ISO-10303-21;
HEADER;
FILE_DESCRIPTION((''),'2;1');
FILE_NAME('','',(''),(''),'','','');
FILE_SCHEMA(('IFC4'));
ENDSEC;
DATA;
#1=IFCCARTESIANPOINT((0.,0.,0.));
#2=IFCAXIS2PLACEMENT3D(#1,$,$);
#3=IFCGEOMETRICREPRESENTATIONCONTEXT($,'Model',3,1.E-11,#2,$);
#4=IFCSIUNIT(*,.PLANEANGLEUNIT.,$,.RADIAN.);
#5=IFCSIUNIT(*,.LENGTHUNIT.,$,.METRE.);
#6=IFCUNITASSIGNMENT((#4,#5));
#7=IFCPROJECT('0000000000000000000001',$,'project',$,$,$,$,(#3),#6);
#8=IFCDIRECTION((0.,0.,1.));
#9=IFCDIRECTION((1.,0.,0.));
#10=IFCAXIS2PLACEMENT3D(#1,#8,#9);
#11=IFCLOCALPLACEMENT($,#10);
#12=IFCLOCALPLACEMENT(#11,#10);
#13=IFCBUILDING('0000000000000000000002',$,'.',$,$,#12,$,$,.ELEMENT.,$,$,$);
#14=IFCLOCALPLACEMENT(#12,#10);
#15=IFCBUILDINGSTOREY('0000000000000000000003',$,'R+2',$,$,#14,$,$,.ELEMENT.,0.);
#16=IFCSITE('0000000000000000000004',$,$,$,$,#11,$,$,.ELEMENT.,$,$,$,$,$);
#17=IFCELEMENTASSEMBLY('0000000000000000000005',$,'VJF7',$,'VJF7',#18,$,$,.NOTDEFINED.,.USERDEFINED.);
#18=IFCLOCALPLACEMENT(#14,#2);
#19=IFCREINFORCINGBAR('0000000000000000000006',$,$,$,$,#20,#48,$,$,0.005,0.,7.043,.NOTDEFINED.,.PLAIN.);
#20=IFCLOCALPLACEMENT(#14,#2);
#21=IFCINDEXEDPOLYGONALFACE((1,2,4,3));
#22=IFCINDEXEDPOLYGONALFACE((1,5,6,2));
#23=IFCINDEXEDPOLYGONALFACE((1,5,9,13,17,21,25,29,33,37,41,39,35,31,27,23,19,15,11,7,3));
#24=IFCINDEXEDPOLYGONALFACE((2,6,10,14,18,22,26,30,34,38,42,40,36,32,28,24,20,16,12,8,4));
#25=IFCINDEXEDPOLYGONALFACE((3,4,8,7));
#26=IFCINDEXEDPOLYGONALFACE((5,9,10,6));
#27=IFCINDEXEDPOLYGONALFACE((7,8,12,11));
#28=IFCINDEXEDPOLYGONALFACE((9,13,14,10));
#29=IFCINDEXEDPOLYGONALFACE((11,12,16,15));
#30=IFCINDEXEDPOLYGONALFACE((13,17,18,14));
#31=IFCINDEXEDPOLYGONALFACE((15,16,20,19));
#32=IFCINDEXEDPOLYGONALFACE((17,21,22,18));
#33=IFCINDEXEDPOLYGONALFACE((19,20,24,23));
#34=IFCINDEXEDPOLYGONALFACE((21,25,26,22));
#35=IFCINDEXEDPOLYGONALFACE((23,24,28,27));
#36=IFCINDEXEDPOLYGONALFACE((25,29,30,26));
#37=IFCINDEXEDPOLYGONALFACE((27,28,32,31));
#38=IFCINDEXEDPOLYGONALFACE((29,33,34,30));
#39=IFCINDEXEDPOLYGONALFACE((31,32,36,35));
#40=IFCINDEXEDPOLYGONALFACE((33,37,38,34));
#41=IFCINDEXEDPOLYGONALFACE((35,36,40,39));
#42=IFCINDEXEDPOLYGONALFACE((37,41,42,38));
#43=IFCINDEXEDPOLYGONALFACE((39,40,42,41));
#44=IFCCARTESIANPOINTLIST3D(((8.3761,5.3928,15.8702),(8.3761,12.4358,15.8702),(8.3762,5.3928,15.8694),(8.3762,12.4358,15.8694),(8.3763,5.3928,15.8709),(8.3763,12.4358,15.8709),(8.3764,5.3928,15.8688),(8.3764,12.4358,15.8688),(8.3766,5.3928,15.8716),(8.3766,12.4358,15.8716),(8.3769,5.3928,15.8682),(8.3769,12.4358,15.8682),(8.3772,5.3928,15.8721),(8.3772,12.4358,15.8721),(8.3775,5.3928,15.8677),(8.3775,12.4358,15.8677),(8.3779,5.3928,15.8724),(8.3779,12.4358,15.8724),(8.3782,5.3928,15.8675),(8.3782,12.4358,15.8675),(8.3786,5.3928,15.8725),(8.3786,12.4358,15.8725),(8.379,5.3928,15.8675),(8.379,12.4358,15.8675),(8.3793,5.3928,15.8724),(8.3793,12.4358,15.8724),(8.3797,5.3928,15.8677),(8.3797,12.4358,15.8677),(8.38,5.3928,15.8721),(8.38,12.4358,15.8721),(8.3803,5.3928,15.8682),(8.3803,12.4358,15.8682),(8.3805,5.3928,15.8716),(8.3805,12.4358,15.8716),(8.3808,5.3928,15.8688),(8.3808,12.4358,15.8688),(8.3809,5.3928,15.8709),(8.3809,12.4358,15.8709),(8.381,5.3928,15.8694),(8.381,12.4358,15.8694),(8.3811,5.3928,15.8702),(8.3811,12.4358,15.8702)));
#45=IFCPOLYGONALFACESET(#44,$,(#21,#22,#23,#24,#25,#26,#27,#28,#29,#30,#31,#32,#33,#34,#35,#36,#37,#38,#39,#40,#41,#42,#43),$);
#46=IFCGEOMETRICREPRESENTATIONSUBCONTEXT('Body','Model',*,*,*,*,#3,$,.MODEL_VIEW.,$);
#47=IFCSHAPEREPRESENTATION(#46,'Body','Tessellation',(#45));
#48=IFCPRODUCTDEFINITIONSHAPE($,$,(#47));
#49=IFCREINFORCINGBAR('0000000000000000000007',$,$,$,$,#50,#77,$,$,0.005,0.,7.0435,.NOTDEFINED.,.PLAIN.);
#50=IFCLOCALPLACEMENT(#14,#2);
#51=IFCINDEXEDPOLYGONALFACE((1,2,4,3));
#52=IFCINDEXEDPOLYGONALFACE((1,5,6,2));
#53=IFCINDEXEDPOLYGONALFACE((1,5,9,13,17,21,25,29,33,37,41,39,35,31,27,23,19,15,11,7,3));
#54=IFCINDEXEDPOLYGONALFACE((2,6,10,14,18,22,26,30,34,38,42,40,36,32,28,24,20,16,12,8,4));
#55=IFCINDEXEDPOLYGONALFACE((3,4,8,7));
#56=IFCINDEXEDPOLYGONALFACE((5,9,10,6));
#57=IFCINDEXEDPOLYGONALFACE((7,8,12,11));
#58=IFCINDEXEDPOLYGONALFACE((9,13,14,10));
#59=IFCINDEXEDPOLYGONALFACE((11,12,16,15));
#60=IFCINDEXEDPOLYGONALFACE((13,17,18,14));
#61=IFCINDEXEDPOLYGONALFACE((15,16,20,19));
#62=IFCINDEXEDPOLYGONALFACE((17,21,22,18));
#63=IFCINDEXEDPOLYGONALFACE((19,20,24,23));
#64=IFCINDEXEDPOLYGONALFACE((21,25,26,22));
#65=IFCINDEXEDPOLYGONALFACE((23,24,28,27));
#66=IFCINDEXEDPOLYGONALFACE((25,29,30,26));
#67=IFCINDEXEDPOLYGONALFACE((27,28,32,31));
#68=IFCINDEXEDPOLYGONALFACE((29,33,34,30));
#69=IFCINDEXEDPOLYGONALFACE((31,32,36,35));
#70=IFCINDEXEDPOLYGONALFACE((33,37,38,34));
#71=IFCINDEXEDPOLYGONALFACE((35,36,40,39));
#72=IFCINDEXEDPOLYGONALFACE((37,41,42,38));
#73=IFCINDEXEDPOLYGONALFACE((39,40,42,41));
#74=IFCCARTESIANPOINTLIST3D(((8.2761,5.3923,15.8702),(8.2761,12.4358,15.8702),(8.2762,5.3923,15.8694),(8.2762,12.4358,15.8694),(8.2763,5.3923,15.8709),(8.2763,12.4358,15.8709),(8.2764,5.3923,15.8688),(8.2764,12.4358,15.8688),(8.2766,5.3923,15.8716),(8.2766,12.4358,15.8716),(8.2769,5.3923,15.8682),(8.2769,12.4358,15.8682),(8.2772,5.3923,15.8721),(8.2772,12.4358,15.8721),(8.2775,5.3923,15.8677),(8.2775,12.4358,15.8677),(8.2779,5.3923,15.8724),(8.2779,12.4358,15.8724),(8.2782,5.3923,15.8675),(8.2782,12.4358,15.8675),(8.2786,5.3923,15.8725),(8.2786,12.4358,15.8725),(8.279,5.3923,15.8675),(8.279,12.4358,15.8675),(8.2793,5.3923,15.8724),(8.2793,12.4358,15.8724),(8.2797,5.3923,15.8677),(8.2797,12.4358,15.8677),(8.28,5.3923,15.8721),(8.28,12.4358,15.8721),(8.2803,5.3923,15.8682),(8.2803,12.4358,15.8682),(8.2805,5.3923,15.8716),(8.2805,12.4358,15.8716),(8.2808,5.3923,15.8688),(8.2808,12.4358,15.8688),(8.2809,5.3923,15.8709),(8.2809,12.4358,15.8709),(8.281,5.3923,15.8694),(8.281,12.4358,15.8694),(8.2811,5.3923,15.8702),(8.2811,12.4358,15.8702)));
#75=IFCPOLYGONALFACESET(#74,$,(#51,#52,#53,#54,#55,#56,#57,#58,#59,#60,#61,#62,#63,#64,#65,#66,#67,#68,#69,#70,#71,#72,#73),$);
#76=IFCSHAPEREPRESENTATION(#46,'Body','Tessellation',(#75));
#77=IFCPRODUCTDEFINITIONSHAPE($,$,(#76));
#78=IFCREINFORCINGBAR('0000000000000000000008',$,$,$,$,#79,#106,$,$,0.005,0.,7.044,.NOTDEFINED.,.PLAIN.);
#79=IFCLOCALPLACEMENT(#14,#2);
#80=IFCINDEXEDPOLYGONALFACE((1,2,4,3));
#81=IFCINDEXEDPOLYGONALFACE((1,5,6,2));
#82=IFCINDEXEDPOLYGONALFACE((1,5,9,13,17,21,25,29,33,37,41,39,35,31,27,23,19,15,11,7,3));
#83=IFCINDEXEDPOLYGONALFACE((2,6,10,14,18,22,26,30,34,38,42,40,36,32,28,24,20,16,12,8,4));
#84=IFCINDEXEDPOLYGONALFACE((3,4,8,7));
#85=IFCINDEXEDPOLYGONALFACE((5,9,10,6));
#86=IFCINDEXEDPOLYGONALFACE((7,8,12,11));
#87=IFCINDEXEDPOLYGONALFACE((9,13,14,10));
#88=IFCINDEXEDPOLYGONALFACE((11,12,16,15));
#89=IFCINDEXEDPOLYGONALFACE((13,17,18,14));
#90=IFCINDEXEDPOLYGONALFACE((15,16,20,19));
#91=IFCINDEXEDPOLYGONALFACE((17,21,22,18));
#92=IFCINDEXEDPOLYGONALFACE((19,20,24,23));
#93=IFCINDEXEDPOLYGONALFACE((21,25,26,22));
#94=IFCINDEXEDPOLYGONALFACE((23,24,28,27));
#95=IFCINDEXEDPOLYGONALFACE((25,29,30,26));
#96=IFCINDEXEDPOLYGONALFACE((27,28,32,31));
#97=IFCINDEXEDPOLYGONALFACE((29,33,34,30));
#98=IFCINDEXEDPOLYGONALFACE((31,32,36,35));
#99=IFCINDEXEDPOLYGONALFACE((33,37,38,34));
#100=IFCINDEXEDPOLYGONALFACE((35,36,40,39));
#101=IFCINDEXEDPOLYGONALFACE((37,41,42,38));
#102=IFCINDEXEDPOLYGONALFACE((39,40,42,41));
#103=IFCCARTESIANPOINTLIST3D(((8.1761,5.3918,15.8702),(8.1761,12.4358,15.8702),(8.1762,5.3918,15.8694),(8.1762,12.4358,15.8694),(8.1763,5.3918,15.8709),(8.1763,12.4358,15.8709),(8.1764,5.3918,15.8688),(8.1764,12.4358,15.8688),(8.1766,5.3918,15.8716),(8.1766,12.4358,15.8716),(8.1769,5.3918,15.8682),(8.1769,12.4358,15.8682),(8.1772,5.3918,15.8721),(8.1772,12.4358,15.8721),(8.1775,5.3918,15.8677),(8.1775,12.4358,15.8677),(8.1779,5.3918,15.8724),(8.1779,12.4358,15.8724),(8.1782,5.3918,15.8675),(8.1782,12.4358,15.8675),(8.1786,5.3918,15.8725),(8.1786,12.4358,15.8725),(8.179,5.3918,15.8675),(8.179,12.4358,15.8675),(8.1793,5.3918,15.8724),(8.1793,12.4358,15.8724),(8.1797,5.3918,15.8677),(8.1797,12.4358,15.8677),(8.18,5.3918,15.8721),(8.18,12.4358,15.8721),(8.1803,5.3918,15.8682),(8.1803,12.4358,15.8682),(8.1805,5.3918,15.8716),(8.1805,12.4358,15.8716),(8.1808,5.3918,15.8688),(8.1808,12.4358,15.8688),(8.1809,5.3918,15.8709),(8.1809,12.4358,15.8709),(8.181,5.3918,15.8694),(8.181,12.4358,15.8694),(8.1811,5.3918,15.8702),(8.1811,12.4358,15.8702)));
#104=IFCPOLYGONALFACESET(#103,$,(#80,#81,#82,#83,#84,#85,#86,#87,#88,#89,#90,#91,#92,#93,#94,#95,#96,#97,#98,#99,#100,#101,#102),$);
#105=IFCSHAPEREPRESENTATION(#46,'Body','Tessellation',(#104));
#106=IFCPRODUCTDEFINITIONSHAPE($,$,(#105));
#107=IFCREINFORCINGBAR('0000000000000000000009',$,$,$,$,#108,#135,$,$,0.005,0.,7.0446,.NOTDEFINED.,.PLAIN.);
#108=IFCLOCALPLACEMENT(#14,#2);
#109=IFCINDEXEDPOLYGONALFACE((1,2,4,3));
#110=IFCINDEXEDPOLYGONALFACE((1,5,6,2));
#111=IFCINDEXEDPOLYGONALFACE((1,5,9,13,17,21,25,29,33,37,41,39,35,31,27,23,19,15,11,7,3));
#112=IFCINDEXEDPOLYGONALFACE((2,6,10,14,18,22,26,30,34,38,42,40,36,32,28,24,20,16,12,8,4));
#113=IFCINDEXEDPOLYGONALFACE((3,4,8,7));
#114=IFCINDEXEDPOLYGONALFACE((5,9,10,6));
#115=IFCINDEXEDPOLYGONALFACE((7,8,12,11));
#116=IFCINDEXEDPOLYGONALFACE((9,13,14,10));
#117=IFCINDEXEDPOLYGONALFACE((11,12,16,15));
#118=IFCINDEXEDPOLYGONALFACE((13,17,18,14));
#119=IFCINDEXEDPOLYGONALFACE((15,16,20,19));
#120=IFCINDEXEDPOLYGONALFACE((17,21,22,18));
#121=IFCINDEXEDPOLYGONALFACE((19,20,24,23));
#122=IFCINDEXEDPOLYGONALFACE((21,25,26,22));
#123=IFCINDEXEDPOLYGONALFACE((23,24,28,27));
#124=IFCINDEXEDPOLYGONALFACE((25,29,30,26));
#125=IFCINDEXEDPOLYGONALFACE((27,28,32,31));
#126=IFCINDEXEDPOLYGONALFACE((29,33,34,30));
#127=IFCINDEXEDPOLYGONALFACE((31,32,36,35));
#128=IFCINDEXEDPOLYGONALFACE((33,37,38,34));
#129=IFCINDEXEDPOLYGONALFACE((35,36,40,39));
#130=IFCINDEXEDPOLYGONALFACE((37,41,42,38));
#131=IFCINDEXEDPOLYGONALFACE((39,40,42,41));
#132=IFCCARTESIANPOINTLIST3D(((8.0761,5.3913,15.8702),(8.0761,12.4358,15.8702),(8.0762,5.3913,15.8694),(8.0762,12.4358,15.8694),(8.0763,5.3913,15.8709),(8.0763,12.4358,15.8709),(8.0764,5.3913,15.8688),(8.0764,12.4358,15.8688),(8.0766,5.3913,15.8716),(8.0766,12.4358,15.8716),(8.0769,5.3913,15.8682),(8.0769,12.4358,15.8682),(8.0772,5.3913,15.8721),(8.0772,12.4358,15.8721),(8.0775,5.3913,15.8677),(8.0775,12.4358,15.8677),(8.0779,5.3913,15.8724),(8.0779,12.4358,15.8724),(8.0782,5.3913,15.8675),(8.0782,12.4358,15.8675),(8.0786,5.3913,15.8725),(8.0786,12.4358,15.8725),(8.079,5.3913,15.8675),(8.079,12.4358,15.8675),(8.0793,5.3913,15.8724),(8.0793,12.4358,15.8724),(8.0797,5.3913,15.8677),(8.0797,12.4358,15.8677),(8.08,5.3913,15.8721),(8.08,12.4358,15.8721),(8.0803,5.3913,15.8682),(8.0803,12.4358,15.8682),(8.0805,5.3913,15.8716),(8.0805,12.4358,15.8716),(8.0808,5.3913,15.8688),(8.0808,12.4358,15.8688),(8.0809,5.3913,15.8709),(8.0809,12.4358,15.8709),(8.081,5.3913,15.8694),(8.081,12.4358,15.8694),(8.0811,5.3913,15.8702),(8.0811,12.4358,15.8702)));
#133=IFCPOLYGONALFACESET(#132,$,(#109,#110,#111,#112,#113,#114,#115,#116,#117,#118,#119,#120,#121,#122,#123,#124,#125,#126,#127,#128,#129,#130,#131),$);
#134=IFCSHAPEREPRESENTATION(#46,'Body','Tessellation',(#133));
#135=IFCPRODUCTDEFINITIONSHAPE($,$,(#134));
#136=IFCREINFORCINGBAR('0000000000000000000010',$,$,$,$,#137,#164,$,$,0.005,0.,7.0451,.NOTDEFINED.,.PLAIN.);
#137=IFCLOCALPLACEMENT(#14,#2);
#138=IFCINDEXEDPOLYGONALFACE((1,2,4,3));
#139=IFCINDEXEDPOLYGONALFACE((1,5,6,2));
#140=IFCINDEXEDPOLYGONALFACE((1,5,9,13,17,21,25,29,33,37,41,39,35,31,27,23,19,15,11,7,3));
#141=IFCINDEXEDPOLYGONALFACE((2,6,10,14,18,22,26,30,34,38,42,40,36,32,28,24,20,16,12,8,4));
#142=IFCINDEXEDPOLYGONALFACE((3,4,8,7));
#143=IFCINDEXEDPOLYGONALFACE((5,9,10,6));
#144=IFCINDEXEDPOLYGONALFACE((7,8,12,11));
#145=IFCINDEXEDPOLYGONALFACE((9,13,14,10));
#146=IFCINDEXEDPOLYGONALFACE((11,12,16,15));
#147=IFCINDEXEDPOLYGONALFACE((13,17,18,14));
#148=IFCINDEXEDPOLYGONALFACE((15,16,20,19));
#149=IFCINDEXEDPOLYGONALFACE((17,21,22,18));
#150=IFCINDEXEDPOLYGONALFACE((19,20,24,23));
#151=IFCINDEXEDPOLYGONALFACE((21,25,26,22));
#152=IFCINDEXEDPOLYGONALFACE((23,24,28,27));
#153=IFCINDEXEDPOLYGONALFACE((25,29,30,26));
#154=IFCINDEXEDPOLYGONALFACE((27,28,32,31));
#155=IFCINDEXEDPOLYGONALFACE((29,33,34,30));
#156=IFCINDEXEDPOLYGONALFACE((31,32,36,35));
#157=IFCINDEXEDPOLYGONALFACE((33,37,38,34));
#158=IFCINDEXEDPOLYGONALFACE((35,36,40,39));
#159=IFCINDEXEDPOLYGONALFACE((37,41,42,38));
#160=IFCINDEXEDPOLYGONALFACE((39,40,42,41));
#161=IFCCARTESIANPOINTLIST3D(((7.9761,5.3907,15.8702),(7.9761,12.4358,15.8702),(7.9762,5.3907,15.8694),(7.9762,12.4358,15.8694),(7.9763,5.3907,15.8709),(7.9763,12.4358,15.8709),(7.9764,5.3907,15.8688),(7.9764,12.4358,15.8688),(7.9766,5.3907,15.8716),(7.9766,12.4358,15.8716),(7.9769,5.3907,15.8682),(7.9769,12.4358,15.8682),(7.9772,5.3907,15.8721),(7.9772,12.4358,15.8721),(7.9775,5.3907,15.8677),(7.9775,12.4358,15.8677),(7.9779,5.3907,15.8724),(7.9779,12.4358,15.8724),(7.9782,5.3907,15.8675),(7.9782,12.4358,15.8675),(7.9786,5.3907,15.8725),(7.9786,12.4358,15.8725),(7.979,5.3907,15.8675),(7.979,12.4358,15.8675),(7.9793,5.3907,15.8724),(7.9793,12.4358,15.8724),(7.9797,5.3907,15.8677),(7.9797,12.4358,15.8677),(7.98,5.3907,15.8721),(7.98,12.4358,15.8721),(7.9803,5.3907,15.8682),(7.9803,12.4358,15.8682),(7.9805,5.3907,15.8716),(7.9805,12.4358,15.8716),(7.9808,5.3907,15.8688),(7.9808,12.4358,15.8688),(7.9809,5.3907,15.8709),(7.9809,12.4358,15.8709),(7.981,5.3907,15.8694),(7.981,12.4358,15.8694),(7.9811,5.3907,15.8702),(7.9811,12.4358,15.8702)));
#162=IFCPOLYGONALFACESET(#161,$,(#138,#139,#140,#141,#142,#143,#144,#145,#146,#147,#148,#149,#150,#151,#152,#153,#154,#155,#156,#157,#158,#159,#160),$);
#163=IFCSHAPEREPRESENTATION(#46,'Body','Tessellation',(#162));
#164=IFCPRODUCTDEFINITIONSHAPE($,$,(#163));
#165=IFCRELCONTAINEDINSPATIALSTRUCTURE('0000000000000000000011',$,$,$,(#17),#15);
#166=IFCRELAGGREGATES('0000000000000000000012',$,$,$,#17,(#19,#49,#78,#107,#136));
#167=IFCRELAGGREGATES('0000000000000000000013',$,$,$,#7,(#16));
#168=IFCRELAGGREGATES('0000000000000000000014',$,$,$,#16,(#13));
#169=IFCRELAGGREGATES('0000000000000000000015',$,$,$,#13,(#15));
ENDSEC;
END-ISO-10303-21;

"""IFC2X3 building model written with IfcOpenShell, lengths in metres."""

from ifc_helpers import new_model, entity, si_unit, origin, origin_with_axes, place, context, subcontext, project, spatial, shape, element, aggregate, save


model = new_model("IFC2X3")

# Units and contexts
model_context = context("Model", 3, precision=1e-11, world=origin())
body_context = subcontext(model_context, "Body", "Model", "MODEL_VIEW")
ifc_project = project(units=[si_unit("PLANEANGLEUNIT", "RADIAN"), si_unit("LENGTHUNIT", "METRE")], contexts=[model_context])

# Site, building, storey
site_placement = place(None, origin_with_axes())
site = spatial("IfcSite", under=ifc_project, at=site_placement, CompositionType="ELEMENT")
building_placement = place(site_placement, origin_with_axes())
building = spatial("IfcBuilding", under=site, at=building_placement, Name=".", CompositionType="ELEMENT")
storey_placement = place(building_placement, origin_with_axes())
storey = spatial("IfcBuildingStorey", under=building, at=storey_placement, Name="R+2", CompositionType="ELEMENT", Elevation=0.0)

# Element assembly, reinforcing bars
assembly_1_placement = place(storey_placement, origin_with_axes())
assembly_1 = element("IfcElementAssembly", 1, at=assembly_1_placement, inside=storey, Name="VJF7", ObjectType="VJF7", AssemblyPlace="NOTDEFINED", PredefinedType="USERDEFINED")
reinforcing_bar_1_placement = place(assembly_1_placement, origin_with_axes())
reinforcing_bar_1 = element("IfcReinforcingBar", 2, at=reinforcing_bar_1_placement, BarLength=7.043, BarRole="NOTDEFINED", BarSurface="PLAIN", CrossSectionArea=0.0, NominalDiameter=0.005, shapes=[
    shape(body_context, "Body", "AdvancedSweptSolid", [entity("IfcSweptDiskSolid", entity("IfcPolyline", [entity("IfcCartesianPoint", [8.3786, 5.3928, 15.87]), entity("IfcCartesianPoint", [8.3786, 12.4358, 15.87])]), 0.0025, None, 0.0, 7.043)]),
    shape(body_context, "Body", "AdvancedSweptSolid", [entity("IfcSweptDiskSolid", entity("IfcPolyline", [entity("IfcCartesianPoint", [8.3786, 5.3928, 15.87]), entity("IfcCartesianPoint", [8.3786, 12.4358, 15.87])]), 0.0025, None, 0.0, 7.043)]),
])
reinforcing_bar_2_placement = place(assembly_1_placement, origin_with_axes())
reinforcing_bar_2 = element("IfcReinforcingBar", 3, at=reinforcing_bar_2_placement, BarLength=7.0435, BarRole="NOTDEFINED", BarSurface="PLAIN", CrossSectionArea=0.0, NominalDiameter=0.005, shapes=[
    shape(body_context, "Body", "AdvancedSweptSolid", [entity("IfcSweptDiskSolid", entity("IfcPolyline", [entity("IfcCartesianPoint", [8.2786, 5.3923, 15.87]), entity("IfcCartesianPoint", [8.2786, 12.4358, 15.87])]), 0.0025, None, 0.0, 7.0435)]),
    shape(body_context, "Body", "AdvancedSweptSolid", [entity("IfcSweptDiskSolid", entity("IfcPolyline", [entity("IfcCartesianPoint", [8.2786, 5.3923, 15.87]), entity("IfcCartesianPoint", [8.2786, 12.4358, 15.87])]), 0.0025, None, 0.0, 7.0435)]),
])
reinforcing_bar_3_placement = place(assembly_1_placement, origin_with_axes())
reinforcing_bar_3 = element("IfcReinforcingBar", 4, at=reinforcing_bar_3_placement, BarLength=7.044, BarRole="NOTDEFINED", BarSurface="PLAIN", CrossSectionArea=0.0, NominalDiameter=0.005, shapes=[
    shape(body_context, "Body", "AdvancedSweptSolid", [entity("IfcSweptDiskSolid", entity("IfcPolyline", [entity("IfcCartesianPoint", [8.1786, 5.3918, 15.87]), entity("IfcCartesianPoint", [8.1786, 12.4358, 15.87])]), 0.0025, None, 0.0, 7.044)]),
    shape(body_context, "Body", "AdvancedSweptSolid", [entity("IfcSweptDiskSolid", entity("IfcPolyline", [entity("IfcCartesianPoint", [8.1786, 5.3918, 15.87]), entity("IfcCartesianPoint", [8.1786, 12.4358, 15.87])]), 0.0025, None, 0.0, 7.044)]),
])
reinforcing_bar_4_placement = place(assembly_1_placement, origin_with_axes())
reinforcing_bar_4 = element("IfcReinforcingBar", 5, at=reinforcing_bar_4_placement, BarLength=7.0446, BarRole="NOTDEFINED", BarSurface="PLAIN", CrossSectionArea=0.0, NominalDiameter=0.005, shapes=[
    shape(body_context, "Body", "AdvancedSweptSolid", [entity("IfcSweptDiskSolid", entity("IfcPolyline", [entity("IfcCartesianPoint", [8.0786, 5.3913, 15.87]), entity("IfcCartesianPoint", [8.0786, 12.4358, 15.87])]), 0.0025, None, 0.0, 7.0446)]),
    shape(body_context, "Body", "AdvancedSweptSolid", [entity("IfcSweptDiskSolid", entity("IfcPolyline", [entity("IfcCartesianPoint", [8.0786, 5.3913, 15.87]), entity("IfcCartesianPoint", [8.0786, 12.4358, 15.87])]), 0.0025, None, 0.0, 7.0446)]),
])
reinforcing_bar_5_placement = place(assembly_1_placement, origin_with_axes())
reinforcing_bar_5 = element("IfcReinforcingBar", 6, at=reinforcing_bar_5_placement, BarLength=7.0451, BarRole="NOTDEFINED", BarSurface="PLAIN", CrossSectionArea=0.0, NominalDiameter=0.005, shapes=[
    shape(body_context, "Body", "AdvancedSweptSolid", [entity("IfcSweptDiskSolid", entity("IfcPolyline", [entity("IfcCartesianPoint", [7.9786, 5.3907, 15.87]), entity("IfcCartesianPoint", [7.9786, 12.4358, 15.87])]), 0.0025, None, 0.0, 7.0451)]),
    shape(body_context, "Body", "AdvancedSweptSolid", [entity("IfcSweptDiskSolid", entity("IfcPolyline", [entity("IfcCartesianPoint", [7.9786, 5.3907, 15.87]), entity("IfcCartesianPoint", [7.9786, 12.4358, 15.87])]), 0.0025, None, 0.0, 7.0451)]),
])
aggregate(assembly_1, [reinforcing_bar_1, reinforcing_bar_2, reinforcing_bar_3, reinforcing_bar_4, reinforcing_bar_5])

save(model, "model.ifc")
